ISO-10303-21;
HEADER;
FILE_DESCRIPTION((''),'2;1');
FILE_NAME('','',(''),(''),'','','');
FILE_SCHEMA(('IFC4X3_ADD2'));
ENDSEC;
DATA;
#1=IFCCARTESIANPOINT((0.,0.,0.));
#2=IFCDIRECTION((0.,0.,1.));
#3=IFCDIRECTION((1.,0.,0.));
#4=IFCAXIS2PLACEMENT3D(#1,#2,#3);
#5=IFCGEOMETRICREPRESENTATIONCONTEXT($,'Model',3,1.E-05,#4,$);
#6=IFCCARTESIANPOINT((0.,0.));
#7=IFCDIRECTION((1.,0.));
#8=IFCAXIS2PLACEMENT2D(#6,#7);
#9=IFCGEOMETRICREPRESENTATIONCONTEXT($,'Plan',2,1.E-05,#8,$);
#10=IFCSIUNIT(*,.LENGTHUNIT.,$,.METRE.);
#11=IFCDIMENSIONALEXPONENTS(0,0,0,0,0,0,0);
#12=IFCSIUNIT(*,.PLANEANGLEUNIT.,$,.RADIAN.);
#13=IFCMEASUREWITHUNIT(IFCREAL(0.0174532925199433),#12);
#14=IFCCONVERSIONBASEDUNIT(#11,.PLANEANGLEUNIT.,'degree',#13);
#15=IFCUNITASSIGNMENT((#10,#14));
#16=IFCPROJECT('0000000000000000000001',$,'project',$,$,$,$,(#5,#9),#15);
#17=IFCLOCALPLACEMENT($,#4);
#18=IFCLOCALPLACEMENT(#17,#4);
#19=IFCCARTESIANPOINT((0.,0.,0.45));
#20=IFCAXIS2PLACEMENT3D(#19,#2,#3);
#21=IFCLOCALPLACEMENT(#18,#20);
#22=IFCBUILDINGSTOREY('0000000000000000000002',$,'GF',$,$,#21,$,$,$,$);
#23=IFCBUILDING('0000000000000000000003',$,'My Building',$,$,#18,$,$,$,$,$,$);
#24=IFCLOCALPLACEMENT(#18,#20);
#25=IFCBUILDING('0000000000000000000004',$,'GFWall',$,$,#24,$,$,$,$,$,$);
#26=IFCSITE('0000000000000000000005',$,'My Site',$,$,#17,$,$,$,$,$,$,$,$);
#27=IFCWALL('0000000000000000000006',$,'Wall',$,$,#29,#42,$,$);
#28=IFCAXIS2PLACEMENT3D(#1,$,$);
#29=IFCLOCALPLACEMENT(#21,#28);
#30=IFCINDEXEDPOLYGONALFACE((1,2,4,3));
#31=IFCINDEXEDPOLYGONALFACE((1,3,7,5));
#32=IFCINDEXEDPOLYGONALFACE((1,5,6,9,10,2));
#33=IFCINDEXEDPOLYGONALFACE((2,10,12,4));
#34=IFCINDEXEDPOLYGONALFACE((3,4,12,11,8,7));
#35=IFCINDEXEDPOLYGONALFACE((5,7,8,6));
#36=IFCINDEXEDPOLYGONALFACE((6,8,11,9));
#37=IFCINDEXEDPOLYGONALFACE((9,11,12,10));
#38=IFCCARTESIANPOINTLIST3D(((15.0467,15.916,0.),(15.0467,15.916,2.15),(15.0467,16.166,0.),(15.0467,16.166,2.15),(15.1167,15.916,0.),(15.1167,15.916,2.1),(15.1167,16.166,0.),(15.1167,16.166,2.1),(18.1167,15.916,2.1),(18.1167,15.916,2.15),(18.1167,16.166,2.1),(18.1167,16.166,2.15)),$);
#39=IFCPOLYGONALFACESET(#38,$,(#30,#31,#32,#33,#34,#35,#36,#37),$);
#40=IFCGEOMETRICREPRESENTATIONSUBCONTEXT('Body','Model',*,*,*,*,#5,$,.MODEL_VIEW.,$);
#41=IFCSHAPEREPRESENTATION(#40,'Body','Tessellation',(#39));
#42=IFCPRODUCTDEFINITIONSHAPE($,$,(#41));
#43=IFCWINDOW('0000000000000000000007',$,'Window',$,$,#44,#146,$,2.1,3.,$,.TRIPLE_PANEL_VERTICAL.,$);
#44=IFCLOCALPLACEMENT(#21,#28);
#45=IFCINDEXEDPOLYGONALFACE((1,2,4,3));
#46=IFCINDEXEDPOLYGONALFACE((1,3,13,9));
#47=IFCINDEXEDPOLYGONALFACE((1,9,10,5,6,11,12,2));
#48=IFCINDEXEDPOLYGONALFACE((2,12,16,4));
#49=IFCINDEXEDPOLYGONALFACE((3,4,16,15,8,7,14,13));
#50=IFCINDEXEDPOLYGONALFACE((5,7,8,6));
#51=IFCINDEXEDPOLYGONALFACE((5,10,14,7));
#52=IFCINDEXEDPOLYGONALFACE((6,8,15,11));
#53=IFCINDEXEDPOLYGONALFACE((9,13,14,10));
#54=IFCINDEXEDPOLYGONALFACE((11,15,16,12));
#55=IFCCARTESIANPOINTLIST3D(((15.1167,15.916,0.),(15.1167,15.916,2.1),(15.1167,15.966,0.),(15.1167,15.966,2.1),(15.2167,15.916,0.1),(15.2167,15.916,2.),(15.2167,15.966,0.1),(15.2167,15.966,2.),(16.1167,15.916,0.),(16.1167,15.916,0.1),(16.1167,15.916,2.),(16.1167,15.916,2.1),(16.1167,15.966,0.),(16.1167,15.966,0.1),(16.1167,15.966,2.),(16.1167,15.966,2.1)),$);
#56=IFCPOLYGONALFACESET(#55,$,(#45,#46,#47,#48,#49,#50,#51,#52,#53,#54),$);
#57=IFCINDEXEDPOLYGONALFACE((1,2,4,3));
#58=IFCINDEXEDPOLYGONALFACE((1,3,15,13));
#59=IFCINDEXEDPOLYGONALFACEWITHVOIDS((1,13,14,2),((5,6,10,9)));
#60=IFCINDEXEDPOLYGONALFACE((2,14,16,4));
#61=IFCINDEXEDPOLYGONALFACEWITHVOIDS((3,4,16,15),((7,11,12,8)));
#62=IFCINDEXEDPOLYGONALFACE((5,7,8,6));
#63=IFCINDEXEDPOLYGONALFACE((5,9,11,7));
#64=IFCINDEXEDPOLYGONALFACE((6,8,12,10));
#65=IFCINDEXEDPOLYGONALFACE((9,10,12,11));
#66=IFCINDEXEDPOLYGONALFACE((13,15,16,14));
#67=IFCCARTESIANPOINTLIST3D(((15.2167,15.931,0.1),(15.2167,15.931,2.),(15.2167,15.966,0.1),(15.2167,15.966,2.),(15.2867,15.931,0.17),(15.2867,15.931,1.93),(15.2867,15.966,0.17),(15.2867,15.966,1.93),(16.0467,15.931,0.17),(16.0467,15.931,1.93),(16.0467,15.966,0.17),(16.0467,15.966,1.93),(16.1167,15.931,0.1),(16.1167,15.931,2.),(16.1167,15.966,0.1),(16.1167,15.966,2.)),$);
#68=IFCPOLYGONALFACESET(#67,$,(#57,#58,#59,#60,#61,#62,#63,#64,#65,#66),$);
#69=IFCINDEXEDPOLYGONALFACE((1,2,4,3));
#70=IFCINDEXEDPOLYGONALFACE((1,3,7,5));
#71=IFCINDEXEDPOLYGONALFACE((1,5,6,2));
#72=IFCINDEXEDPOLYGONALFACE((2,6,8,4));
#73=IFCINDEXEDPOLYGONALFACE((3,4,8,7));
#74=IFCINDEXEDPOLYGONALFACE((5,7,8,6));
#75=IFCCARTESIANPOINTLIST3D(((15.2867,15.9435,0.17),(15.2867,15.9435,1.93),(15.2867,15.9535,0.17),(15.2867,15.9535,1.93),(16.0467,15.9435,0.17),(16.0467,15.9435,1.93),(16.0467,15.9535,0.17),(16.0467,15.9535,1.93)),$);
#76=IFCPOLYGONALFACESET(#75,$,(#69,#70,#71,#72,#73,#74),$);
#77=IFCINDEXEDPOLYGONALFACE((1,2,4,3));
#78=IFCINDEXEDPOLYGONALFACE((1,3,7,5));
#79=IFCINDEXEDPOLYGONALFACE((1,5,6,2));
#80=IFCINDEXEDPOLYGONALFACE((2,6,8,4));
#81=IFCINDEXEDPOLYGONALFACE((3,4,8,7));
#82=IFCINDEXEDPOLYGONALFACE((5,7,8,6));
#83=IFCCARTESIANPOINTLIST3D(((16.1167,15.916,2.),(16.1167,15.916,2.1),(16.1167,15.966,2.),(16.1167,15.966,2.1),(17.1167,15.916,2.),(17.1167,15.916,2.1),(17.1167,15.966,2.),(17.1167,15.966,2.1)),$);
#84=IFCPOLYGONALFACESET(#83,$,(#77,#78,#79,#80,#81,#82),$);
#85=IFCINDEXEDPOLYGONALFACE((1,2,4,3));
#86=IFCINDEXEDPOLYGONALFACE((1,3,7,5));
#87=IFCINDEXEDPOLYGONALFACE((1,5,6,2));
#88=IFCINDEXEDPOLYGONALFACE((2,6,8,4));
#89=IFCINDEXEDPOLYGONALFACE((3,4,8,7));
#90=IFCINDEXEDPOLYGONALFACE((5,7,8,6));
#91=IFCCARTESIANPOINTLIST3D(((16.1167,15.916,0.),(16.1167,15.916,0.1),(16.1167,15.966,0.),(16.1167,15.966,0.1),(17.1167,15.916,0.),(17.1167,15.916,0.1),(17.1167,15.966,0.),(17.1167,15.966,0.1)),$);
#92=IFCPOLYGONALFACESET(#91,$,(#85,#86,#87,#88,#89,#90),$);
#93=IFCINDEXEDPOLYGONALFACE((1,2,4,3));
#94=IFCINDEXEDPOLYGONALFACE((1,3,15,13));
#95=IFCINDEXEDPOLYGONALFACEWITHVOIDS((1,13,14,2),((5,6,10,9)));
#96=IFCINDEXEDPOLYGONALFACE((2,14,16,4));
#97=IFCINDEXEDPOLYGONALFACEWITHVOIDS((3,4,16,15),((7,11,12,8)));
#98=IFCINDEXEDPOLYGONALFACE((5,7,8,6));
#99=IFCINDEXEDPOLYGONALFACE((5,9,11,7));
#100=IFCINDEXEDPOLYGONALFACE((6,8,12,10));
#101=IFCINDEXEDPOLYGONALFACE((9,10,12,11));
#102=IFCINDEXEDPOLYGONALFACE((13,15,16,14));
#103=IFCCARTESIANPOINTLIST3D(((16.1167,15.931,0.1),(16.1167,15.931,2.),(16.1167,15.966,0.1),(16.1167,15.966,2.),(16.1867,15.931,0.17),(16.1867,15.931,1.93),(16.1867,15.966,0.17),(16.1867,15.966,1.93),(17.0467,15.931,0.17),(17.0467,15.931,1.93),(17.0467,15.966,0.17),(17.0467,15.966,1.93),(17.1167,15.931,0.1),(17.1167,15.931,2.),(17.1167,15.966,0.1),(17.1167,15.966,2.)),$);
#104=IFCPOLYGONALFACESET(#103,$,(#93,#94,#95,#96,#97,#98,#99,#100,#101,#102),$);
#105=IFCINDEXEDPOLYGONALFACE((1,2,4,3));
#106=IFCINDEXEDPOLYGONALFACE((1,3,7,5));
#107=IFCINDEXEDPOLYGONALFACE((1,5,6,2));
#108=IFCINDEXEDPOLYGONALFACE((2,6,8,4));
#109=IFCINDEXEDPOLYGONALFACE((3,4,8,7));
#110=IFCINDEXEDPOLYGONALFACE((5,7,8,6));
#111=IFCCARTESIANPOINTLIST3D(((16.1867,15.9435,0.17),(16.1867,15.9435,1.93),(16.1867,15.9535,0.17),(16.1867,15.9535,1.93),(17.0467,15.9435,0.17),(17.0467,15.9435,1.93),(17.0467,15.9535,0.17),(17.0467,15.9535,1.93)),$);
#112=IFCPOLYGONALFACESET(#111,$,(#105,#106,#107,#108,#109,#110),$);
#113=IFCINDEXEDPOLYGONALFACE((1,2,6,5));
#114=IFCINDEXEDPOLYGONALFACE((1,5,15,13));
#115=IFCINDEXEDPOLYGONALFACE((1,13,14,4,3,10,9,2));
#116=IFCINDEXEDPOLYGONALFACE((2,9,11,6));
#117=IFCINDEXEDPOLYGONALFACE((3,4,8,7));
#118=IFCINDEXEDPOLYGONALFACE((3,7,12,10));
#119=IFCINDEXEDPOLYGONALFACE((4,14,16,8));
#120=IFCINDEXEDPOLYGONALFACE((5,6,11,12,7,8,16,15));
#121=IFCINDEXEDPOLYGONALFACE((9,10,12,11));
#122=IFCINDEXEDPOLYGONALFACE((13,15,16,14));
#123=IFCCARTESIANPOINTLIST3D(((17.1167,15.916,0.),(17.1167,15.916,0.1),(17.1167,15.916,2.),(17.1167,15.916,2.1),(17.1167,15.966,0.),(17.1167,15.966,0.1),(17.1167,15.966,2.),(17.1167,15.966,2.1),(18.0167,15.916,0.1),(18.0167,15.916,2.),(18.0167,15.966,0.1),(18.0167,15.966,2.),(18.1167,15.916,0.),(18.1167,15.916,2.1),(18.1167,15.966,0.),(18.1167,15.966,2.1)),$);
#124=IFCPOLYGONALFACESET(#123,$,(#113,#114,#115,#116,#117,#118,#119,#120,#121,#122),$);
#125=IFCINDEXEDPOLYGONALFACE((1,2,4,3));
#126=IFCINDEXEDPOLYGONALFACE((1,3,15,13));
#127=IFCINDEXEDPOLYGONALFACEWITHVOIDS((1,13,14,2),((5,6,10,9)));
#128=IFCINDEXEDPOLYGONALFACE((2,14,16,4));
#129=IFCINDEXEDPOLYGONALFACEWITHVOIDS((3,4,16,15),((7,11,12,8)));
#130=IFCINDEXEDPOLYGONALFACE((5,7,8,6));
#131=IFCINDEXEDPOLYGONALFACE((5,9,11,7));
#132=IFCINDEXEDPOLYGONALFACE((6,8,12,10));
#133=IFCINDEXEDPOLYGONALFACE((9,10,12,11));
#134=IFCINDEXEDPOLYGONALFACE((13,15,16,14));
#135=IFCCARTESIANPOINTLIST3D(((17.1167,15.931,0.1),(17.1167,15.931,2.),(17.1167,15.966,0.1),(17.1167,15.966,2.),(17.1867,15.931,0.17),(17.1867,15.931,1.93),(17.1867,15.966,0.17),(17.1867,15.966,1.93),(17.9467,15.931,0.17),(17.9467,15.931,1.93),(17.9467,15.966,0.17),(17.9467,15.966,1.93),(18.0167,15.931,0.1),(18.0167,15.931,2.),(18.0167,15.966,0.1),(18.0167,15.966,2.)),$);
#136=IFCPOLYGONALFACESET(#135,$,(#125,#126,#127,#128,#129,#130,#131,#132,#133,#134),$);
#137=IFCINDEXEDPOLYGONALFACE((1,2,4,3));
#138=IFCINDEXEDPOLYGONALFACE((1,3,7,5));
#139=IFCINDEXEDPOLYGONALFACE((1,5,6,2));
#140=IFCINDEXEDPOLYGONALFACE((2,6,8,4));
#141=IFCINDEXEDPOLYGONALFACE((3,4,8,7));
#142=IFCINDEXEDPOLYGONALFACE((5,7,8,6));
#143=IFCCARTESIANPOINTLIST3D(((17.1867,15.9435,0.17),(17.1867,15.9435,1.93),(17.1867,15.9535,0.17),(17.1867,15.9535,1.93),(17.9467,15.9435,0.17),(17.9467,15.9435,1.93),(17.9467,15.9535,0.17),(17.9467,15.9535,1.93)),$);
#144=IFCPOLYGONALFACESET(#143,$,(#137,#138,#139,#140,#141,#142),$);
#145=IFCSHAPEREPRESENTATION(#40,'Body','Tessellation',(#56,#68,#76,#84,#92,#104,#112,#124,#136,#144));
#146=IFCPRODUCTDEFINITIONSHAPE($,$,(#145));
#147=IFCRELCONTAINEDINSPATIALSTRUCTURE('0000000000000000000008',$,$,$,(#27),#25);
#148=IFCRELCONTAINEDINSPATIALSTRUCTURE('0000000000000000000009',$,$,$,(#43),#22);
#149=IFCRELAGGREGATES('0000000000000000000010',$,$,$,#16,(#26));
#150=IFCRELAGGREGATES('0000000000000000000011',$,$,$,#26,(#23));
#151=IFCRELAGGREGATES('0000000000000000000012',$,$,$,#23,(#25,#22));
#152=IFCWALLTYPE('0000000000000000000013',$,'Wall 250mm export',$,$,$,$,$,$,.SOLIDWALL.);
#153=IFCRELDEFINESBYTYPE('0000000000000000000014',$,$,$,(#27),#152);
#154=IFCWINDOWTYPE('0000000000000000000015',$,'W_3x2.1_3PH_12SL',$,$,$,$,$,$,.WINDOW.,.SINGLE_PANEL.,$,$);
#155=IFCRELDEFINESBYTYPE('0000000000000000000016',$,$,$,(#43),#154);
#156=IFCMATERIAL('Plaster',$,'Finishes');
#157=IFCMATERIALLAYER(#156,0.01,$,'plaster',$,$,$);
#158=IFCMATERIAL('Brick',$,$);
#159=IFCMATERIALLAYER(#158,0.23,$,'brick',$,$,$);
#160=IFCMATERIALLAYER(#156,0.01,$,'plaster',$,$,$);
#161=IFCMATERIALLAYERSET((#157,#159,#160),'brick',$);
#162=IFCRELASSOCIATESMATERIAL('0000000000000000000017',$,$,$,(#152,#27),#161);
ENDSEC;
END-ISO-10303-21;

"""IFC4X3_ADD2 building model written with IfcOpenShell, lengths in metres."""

from ifc_helpers import new_model, entity, si_unit, converted_unit, frame, origin_with_axes, origin_2d_with_axis, place, context, subcontext, project, spatial, line, indexed_curve, outline, extrude, shape, source, transform, mapped, material, layer, layer_set, layer_usage, type_object, type_shapes, element, fill, save


model = new_model("IFC4X3_ADD2")

# Units and contexts
model_context = context("Model", 3, precision=1e-05, world=origin_with_axes())
plan_context = context("Plan", 2, precision=1e-05, world=origin_2d_with_axis())
body_context_1 = subcontext(model_context, "Body", "Model", "MODEL_VIEW")
body_context_2 = subcontext(plan_context, "Body", "Plan", "PLAN_VIEW")
ifc_project = project(units=[si_unit("LENGTHUNIT", "METRE"), converted_unit("PLANEANGLEUNIT", "degree", entity("IfcReal", 0.0174532925199433), si_unit("PLANEANGLEUNIT", "RADIAN"), dimensions=[0, 0, 0, 0, 0, 0, 0])], contexts=[model_context, plan_context])

# Site, buildings
site_placement = place(None, origin_with_axes())
site = spatial("IfcSite", under=ifc_project, at=site_placement, Name="My Site")
building_1_placement = place(site_placement, origin_with_axes())
building_1 = spatial("IfcBuilding", under=site, at=building_1_placement, Name="My Building")
building_2_placement = place(building_1_placement, frame((0.0, 0.0, 0.45), z_axis=(0.0, 0.0, 1.0), x_axis=(1.0, 0.0, 0.0)))
building_2 = spatial("IfcBuilding", under=building_1, at=building_2_placement, Name="GFWall")

# Shared definitions
storey_placement = place(building_1_placement, frame((0.0, 0.0, 0.45), z_axis=(0.0, 0.0, 1.0), x_axis=(1.0, 0.0, 0.0)))
storey = spatial("IfcBuildingStorey", under=building_1, at=storey_placement, Name="GF")

# Shared definitions
ifc_material_1 = material(Name="Plaster", Category="Finishes")

# Wall, opening, window
ifc_layer_1 = layer(ifc_material_1, 0.01, Name="plaster")
ifc_material_2 = material(Name="Brick")
ifc_layer_2 = layer(ifc_material_2, 0.23, Name="brick")
ifc_layer_3 = layer(ifc_material_1, 0.01, Name="plaster")
ifc_layer_set_1 = layer_set([ifc_layer_1, ifc_layer_2, ifc_layer_3], Name="brick")
ifc_layer_usage_1 = layer_usage(ifc_layer_set_1, "AXIS2", "POSITIVE", 0.0)
wall_type_1 = type_object("IfcWallType", Name="Wall 250mm export", PredefinedType="SOLIDWALL", material=ifc_layer_set_1)
wall_1_placement = place(building_2_placement, frame((15.0467, 15.916, 0.0), z_axis=(0.0, 0.0, 1.0), x_axis=(1.0, 0.0, 0.0)))
wall_1 = element("IfcWall", 1, at=wall_1_placement, inside=building_2, type_object=wall_type_1, material=ifc_layer_usage_1, Name="Wall", context=body_context_1, shape_type="SweptSolid", body=[
    extrude(outline(indexed_curve([(0.0, 0.0), (0.0, 0.25), (3.07, 0.25), (3.07, 0.0)], segments=[line(1, 2, 3, 4, 1)])), origin_with_axes(), (0.0, 0.0, 1.0), 2.15),
])
shared_shape_1 = source(origin_with_axes(), body_context_1, "Body", "SweptSolid", [
    extrude(outline(indexed_curve([(0.0, 0.0), (3.0, 0.0), (3.0, 2.1), (0.0, 2.1)], segments=[line(1, 2, 3, 4, 1)])), frame((0.0, -0.6, 0.0), z_axis=(0.0, -1.0, 0.0), x_axis=(1.0, 0.0, 0.0)), (0.0, 0.0, -1.0), 1.2),
])
opening_1_placement = place(wall_1_placement, frame((0.07, 0.0, 0.0), z_axis=(0.0, 0.0, 1.0), x_axis=(1.0, 0.0, 0.0)))
opening_1 = element("IfcOpeningElement", 2, at=opening_1_placement, cuts=wall_1, PredefinedType="OPENING", context=body_context_1, shape_type="MappedRepresentation", body=[
    mapped(shared_shape_1, transform((0.0, 0.0, 0.0), x_axis=(1.0, 0.0, 0.0), y_axis=(0.0, 1.0, 0.0), z_axis=(0.0, 0.0, 1.0), scale=1.0)),
])
window_type_1 = type_object("IfcWindowType", Name="W_3x2.1_3PH_12SL", PartitioningType="SINGLE_PANEL", PredefinedType="WINDOW")
shared_shape_2 = source(origin_with_axes(), body_context_1, "Body", "SweptSolid", [
    extrude(outline(indexed_curve([(1.0, 0.0), (0.0, 0.0), (0.0, 2.1), (1.0, 2.1), (1.0, 2.0), (0.1, 2.0), (0.1, 0.1), (1.0, 0.1)], segments=[line(1, 2, 3, 4, 5, 6, 7, 8, 1)])), frame((0.0, 0.0, 0.0), z_axis=(0.0, -1.0, 0.0), x_axis=(1.0, 0.0, 0.0)), (0.0, 0.0, -1.0), 0.05),
    extrude(outline(indexed_curve([(0.0, 0.0), (0.9, 0.0), (0.9, 1.9), (0.0, 1.9)], segments=[line(1, 2, 3, 4, 1)]), holes=[indexed_curve([(0.07, 0.07), (0.83, 0.07), (0.83, 1.83), (0.07, 1.83)], segments=[line(1, 2, 3, 4, 1)])]), frame((0.1, 0.015, 0.1), z_axis=(0.0, -1.0, 0.0), x_axis=(1.0, 0.0, 0.0)), (0.0, 0.0, -1.0), 0.035),
    extrude(outline(indexed_curve([(0.07, 0.07), (0.83, 0.07), (0.83, 1.83), (0.07, 1.83)], segments=[line(1, 2, 3, 4, 1)])), frame((0.1, 0.0275, 0.1), z_axis=(0.0, -1.0, 0.0), x_axis=(1.0, 0.0, 0.0)), (0.0, 0.0, -1.0), 0.01),
    extrude(outline(indexed_curve([(0.0, 2.1), (1.0, 2.1), (1.0, 2.0), (0.0, 2.0)], segments=[line(1, 2, 3, 4, 1)])), frame((1.0, 0.0, 0.0), z_axis=(0.0, -1.0, 0.0), x_axis=(1.0, 0.0, 0.0)), (0.0, 0.0, -1.0), 0.05),
    extrude(outline(indexed_curve([(1.0, 0.0), (0.0, 0.0), (0.0, 0.1), (1.0, 0.1)], segments=[line(1, 2, 3, 4, 1)])), frame((1.0, 0.0, 0.0), z_axis=(0.0, -1.0, 0.0), x_axis=(1.0, 0.0, 0.0)), (0.0, 0.0, -1.0), 0.05),
    extrude(outline(indexed_curve([(0.0, 0.0), (1.0, 0.0), (1.0, 1.9), (0.0, 1.9)], segments=[line(1, 2, 3, 4, 1)]), holes=[indexed_curve([(0.07, 0.07), (0.93, 0.07), (0.93, 1.83), (0.07, 1.83)], segments=[line(1, 2, 3, 4, 1)])]), frame((1.0, 0.015, 0.1), z_axis=(0.0, -1.0, 0.0), x_axis=(1.0, 0.0, 0.0)), (0.0, 0.0, -1.0), 0.035),
    extrude(outline(indexed_curve([(0.07, 0.07), (0.93, 0.07), (0.93, 1.83), (0.07, 1.83)], segments=[line(1, 2, 3, 4, 1)])), frame((1.0, 0.0275, 0.1), z_axis=(0.0, -1.0, 0.0), x_axis=(1.0, 0.0, 0.0)), (0.0, 0.0, -1.0), 0.01),
    extrude(outline(indexed_curve([(0.0, 2.1), (1.0, 2.1), (1.0, 0.0), (0.0, 0.0), (0.0, 0.1), (0.9, 0.1), (0.9, 2.0), (0.0, 2.0)], segments=[line(1, 2, 3, 4, 5, 6, 7, 8, 1)])), frame((2.0, 0.0, 0.0), z_axis=(0.0, -1.0, 0.0), x_axis=(1.0, 0.0, 0.0)), (0.0, 0.0, -1.0), 0.05),
    extrude(outline(indexed_curve([(0.0, 0.0), (0.9, 0.0), (0.9, 1.9), (0.0, 1.9)], segments=[line(1, 2, 3, 4, 1)]), holes=[indexed_curve([(0.07, 0.07), (0.83, 0.07), (0.83, 1.83), (0.07, 1.83)], segments=[line(1, 2, 3, 4, 1)])]), frame((2.0, 0.015, 0.1), z_axis=(0.0, -1.0, 0.0), x_axis=(1.0, 0.0, 0.0)), (0.0, 0.0, -1.0), 0.035),
    extrude(outline(indexed_curve([(0.07, 0.07), (0.83, 0.07), (0.83, 1.83), (0.07, 1.83)], segments=[line(1, 2, 3, 4, 1)])), frame((2.0, 0.0275, 0.1), z_axis=(0.0, -1.0, 0.0), x_axis=(1.0, 0.0, 0.0)), (0.0, 0.0, -1.0), 0.01),
])
shared_shape_3 = source(origin_with_axes(), body_context_2, "Body", "Curve2D", [
    entity("IfcIndexedPolyCurve", entity("IfcCartesianPointList2D", [[0.1, 0.0], [1.0, 0.0]])),
    entity("IfcIndexedPolyCurve", entity("IfcCartesianPointList2D", [[0.0, 0.05], [0.1, 0.05], [0.1, 0.0], [0.0, 0.0]]), [entity("IfcLineIndex", [1, 2, 3, 4, 1])]),
    entity("IfcIndexedPolyCurve", entity("IfcCartesianPointList2D", [[1.0, 0.05], [1.0, 0.05], [1.0, 0.0], [1.0, 0.0]])),
    entity("IfcIndexedPolyCurve", entity("IfcCartesianPointList2D", [[0.1, 0.015], [0.17, 0.015], [0.17, 0.05], [0.1, 0.05]]), [entity("IfcLineIndex", [1, 2, 3, 4, 1])]),
    entity("IfcIndexedPolyCurve", entity("IfcCartesianPointList2D", [[1.0, 0.015], [0.93, 0.015], [0.93, 0.05], [1.0, 0.05]]), [entity("IfcLineIndex", [1, 2, 3, 4, 1])]),
    entity("IfcIndexedPolyCurve", entity("IfcCartesianPointList2D", [[0.17, 0.015], [0.93, 0.015]])),
    entity("IfcIndexedPolyCurve", entity("IfcCartesianPointList2D", [[0.17, 0.05], [0.93, 0.05]])),
    entity("IfcIndexedPolyCurve", entity("IfcCartesianPointList2D", [[0.17, 0.0325], [0.93, 0.0325]])),
    entity("IfcIndexedPolyCurve", entity("IfcCartesianPointList2D", [[1.0, 0.0], [2.0, 0.0]])),
    entity("IfcIndexedPolyCurve", entity("IfcCartesianPointList2D", [[1.0, 0.05], [1.0, 0.05], [1.0, 0.0], [1.0, 0.0]])),
    entity("IfcIndexedPolyCurve", entity("IfcCartesianPointList2D", [[2.0, 0.05], [2.0, 0.05], [2.0, 0.0], [2.0, 0.0]])),
    entity("IfcIndexedPolyCurve", entity("IfcCartesianPointList2D", [[1.0, 0.015], [1.07, 0.015], [1.07, 0.05], [1.0, 0.05]]), [entity("IfcLineIndex", [1, 2, 3, 4, 1])]),
    entity("IfcIndexedPolyCurve", entity("IfcCartesianPointList2D", [[2.0, 0.015], [1.93, 0.015], [1.93, 0.05], [2.0, 0.05]]), [entity("IfcLineIndex", [1, 2, 3, 4, 1])]),
    entity("IfcIndexedPolyCurve", entity("IfcCartesianPointList2D", [[1.07, 0.015], [1.93, 0.015]])),
    entity("IfcIndexedPolyCurve", entity("IfcCartesianPointList2D", [[1.07, 0.05], [1.93, 0.05]])),
    entity("IfcIndexedPolyCurve", entity("IfcCartesianPointList2D", [[1.07, 0.0325], [1.93, 0.0325]])),
    entity("IfcIndexedPolyCurve", entity("IfcCartesianPointList2D", [[2.0, 0.0], [2.9, 0.0]])),
    entity("IfcIndexedPolyCurve", entity("IfcCartesianPointList2D", [[2.0, 0.05], [2.0, 0.05], [2.0, 0.0], [2.0, 0.0]])),
    entity("IfcIndexedPolyCurve", entity("IfcCartesianPointList2D", [[3.0, 0.05], [2.9, 0.05], [2.9, 0.0], [3.0, 0.0]]), [entity("IfcLineIndex", [1, 2, 3, 4, 1])]),
    entity("IfcIndexedPolyCurve", entity("IfcCartesianPointList2D", [[2.0, 0.015], [2.07, 0.015], [2.07, 0.05], [2.0, 0.05]]), [entity("IfcLineIndex", [1, 2, 3, 4, 1])]),
    entity("IfcIndexedPolyCurve", entity("IfcCartesianPointList2D", [[2.9, 0.015], [2.83, 0.015], [2.83, 0.05], [2.9, 0.05]]), [entity("IfcLineIndex", [1, 2, 3, 4, 1])]),
    entity("IfcIndexedPolyCurve", entity("IfcCartesianPointList2D", [[2.07, 0.015], [2.83, 0.015]])),
    entity("IfcIndexedPolyCurve", entity("IfcCartesianPointList2D", [[2.07, 0.05], [2.83, 0.05]])),
    entity("IfcIndexedPolyCurve", entity("IfcCartesianPointList2D", [[2.07, 0.0325], [2.83, 0.0325]])),
])
type_shapes(window_type_1, [shared_shape_2, shared_shape_3])
window_1_placement = place(opening_1_placement, origin_with_axes())
window_1 = element("IfcWindow", 3, at=window_1_placement, inside=storey, type_object=window_type_1, Name="Window", OverallHeight=2.1, OverallWidth=3.0, PartitioningType="TRIPLE_PANEL_VERTICAL", shapes=[
    shape(body_context_1, "Body", "MappedRepresentation", [mapped(shared_shape_2, transform((0.0, 0.0, 0.0), x_axis=(1.0, 0.0, 0.0), y_axis=(0.0, 1.0, 0.0), z_axis=(0.0, 0.0, 1.0), scale=1.0))]),
    shape(body_context_2, "Body", "MappedRepresentation", [mapped(shared_shape_3, transform((0.0, 0.0, 0.0), x_axis=(1.0, 0.0, 0.0), y_axis=(0.0, 1.0, 0.0), z_axis=(0.0, 0.0, 1.0), scale=1.0))]),
])
fill(opening_1, window_1)

save(model, "model.ifc")
